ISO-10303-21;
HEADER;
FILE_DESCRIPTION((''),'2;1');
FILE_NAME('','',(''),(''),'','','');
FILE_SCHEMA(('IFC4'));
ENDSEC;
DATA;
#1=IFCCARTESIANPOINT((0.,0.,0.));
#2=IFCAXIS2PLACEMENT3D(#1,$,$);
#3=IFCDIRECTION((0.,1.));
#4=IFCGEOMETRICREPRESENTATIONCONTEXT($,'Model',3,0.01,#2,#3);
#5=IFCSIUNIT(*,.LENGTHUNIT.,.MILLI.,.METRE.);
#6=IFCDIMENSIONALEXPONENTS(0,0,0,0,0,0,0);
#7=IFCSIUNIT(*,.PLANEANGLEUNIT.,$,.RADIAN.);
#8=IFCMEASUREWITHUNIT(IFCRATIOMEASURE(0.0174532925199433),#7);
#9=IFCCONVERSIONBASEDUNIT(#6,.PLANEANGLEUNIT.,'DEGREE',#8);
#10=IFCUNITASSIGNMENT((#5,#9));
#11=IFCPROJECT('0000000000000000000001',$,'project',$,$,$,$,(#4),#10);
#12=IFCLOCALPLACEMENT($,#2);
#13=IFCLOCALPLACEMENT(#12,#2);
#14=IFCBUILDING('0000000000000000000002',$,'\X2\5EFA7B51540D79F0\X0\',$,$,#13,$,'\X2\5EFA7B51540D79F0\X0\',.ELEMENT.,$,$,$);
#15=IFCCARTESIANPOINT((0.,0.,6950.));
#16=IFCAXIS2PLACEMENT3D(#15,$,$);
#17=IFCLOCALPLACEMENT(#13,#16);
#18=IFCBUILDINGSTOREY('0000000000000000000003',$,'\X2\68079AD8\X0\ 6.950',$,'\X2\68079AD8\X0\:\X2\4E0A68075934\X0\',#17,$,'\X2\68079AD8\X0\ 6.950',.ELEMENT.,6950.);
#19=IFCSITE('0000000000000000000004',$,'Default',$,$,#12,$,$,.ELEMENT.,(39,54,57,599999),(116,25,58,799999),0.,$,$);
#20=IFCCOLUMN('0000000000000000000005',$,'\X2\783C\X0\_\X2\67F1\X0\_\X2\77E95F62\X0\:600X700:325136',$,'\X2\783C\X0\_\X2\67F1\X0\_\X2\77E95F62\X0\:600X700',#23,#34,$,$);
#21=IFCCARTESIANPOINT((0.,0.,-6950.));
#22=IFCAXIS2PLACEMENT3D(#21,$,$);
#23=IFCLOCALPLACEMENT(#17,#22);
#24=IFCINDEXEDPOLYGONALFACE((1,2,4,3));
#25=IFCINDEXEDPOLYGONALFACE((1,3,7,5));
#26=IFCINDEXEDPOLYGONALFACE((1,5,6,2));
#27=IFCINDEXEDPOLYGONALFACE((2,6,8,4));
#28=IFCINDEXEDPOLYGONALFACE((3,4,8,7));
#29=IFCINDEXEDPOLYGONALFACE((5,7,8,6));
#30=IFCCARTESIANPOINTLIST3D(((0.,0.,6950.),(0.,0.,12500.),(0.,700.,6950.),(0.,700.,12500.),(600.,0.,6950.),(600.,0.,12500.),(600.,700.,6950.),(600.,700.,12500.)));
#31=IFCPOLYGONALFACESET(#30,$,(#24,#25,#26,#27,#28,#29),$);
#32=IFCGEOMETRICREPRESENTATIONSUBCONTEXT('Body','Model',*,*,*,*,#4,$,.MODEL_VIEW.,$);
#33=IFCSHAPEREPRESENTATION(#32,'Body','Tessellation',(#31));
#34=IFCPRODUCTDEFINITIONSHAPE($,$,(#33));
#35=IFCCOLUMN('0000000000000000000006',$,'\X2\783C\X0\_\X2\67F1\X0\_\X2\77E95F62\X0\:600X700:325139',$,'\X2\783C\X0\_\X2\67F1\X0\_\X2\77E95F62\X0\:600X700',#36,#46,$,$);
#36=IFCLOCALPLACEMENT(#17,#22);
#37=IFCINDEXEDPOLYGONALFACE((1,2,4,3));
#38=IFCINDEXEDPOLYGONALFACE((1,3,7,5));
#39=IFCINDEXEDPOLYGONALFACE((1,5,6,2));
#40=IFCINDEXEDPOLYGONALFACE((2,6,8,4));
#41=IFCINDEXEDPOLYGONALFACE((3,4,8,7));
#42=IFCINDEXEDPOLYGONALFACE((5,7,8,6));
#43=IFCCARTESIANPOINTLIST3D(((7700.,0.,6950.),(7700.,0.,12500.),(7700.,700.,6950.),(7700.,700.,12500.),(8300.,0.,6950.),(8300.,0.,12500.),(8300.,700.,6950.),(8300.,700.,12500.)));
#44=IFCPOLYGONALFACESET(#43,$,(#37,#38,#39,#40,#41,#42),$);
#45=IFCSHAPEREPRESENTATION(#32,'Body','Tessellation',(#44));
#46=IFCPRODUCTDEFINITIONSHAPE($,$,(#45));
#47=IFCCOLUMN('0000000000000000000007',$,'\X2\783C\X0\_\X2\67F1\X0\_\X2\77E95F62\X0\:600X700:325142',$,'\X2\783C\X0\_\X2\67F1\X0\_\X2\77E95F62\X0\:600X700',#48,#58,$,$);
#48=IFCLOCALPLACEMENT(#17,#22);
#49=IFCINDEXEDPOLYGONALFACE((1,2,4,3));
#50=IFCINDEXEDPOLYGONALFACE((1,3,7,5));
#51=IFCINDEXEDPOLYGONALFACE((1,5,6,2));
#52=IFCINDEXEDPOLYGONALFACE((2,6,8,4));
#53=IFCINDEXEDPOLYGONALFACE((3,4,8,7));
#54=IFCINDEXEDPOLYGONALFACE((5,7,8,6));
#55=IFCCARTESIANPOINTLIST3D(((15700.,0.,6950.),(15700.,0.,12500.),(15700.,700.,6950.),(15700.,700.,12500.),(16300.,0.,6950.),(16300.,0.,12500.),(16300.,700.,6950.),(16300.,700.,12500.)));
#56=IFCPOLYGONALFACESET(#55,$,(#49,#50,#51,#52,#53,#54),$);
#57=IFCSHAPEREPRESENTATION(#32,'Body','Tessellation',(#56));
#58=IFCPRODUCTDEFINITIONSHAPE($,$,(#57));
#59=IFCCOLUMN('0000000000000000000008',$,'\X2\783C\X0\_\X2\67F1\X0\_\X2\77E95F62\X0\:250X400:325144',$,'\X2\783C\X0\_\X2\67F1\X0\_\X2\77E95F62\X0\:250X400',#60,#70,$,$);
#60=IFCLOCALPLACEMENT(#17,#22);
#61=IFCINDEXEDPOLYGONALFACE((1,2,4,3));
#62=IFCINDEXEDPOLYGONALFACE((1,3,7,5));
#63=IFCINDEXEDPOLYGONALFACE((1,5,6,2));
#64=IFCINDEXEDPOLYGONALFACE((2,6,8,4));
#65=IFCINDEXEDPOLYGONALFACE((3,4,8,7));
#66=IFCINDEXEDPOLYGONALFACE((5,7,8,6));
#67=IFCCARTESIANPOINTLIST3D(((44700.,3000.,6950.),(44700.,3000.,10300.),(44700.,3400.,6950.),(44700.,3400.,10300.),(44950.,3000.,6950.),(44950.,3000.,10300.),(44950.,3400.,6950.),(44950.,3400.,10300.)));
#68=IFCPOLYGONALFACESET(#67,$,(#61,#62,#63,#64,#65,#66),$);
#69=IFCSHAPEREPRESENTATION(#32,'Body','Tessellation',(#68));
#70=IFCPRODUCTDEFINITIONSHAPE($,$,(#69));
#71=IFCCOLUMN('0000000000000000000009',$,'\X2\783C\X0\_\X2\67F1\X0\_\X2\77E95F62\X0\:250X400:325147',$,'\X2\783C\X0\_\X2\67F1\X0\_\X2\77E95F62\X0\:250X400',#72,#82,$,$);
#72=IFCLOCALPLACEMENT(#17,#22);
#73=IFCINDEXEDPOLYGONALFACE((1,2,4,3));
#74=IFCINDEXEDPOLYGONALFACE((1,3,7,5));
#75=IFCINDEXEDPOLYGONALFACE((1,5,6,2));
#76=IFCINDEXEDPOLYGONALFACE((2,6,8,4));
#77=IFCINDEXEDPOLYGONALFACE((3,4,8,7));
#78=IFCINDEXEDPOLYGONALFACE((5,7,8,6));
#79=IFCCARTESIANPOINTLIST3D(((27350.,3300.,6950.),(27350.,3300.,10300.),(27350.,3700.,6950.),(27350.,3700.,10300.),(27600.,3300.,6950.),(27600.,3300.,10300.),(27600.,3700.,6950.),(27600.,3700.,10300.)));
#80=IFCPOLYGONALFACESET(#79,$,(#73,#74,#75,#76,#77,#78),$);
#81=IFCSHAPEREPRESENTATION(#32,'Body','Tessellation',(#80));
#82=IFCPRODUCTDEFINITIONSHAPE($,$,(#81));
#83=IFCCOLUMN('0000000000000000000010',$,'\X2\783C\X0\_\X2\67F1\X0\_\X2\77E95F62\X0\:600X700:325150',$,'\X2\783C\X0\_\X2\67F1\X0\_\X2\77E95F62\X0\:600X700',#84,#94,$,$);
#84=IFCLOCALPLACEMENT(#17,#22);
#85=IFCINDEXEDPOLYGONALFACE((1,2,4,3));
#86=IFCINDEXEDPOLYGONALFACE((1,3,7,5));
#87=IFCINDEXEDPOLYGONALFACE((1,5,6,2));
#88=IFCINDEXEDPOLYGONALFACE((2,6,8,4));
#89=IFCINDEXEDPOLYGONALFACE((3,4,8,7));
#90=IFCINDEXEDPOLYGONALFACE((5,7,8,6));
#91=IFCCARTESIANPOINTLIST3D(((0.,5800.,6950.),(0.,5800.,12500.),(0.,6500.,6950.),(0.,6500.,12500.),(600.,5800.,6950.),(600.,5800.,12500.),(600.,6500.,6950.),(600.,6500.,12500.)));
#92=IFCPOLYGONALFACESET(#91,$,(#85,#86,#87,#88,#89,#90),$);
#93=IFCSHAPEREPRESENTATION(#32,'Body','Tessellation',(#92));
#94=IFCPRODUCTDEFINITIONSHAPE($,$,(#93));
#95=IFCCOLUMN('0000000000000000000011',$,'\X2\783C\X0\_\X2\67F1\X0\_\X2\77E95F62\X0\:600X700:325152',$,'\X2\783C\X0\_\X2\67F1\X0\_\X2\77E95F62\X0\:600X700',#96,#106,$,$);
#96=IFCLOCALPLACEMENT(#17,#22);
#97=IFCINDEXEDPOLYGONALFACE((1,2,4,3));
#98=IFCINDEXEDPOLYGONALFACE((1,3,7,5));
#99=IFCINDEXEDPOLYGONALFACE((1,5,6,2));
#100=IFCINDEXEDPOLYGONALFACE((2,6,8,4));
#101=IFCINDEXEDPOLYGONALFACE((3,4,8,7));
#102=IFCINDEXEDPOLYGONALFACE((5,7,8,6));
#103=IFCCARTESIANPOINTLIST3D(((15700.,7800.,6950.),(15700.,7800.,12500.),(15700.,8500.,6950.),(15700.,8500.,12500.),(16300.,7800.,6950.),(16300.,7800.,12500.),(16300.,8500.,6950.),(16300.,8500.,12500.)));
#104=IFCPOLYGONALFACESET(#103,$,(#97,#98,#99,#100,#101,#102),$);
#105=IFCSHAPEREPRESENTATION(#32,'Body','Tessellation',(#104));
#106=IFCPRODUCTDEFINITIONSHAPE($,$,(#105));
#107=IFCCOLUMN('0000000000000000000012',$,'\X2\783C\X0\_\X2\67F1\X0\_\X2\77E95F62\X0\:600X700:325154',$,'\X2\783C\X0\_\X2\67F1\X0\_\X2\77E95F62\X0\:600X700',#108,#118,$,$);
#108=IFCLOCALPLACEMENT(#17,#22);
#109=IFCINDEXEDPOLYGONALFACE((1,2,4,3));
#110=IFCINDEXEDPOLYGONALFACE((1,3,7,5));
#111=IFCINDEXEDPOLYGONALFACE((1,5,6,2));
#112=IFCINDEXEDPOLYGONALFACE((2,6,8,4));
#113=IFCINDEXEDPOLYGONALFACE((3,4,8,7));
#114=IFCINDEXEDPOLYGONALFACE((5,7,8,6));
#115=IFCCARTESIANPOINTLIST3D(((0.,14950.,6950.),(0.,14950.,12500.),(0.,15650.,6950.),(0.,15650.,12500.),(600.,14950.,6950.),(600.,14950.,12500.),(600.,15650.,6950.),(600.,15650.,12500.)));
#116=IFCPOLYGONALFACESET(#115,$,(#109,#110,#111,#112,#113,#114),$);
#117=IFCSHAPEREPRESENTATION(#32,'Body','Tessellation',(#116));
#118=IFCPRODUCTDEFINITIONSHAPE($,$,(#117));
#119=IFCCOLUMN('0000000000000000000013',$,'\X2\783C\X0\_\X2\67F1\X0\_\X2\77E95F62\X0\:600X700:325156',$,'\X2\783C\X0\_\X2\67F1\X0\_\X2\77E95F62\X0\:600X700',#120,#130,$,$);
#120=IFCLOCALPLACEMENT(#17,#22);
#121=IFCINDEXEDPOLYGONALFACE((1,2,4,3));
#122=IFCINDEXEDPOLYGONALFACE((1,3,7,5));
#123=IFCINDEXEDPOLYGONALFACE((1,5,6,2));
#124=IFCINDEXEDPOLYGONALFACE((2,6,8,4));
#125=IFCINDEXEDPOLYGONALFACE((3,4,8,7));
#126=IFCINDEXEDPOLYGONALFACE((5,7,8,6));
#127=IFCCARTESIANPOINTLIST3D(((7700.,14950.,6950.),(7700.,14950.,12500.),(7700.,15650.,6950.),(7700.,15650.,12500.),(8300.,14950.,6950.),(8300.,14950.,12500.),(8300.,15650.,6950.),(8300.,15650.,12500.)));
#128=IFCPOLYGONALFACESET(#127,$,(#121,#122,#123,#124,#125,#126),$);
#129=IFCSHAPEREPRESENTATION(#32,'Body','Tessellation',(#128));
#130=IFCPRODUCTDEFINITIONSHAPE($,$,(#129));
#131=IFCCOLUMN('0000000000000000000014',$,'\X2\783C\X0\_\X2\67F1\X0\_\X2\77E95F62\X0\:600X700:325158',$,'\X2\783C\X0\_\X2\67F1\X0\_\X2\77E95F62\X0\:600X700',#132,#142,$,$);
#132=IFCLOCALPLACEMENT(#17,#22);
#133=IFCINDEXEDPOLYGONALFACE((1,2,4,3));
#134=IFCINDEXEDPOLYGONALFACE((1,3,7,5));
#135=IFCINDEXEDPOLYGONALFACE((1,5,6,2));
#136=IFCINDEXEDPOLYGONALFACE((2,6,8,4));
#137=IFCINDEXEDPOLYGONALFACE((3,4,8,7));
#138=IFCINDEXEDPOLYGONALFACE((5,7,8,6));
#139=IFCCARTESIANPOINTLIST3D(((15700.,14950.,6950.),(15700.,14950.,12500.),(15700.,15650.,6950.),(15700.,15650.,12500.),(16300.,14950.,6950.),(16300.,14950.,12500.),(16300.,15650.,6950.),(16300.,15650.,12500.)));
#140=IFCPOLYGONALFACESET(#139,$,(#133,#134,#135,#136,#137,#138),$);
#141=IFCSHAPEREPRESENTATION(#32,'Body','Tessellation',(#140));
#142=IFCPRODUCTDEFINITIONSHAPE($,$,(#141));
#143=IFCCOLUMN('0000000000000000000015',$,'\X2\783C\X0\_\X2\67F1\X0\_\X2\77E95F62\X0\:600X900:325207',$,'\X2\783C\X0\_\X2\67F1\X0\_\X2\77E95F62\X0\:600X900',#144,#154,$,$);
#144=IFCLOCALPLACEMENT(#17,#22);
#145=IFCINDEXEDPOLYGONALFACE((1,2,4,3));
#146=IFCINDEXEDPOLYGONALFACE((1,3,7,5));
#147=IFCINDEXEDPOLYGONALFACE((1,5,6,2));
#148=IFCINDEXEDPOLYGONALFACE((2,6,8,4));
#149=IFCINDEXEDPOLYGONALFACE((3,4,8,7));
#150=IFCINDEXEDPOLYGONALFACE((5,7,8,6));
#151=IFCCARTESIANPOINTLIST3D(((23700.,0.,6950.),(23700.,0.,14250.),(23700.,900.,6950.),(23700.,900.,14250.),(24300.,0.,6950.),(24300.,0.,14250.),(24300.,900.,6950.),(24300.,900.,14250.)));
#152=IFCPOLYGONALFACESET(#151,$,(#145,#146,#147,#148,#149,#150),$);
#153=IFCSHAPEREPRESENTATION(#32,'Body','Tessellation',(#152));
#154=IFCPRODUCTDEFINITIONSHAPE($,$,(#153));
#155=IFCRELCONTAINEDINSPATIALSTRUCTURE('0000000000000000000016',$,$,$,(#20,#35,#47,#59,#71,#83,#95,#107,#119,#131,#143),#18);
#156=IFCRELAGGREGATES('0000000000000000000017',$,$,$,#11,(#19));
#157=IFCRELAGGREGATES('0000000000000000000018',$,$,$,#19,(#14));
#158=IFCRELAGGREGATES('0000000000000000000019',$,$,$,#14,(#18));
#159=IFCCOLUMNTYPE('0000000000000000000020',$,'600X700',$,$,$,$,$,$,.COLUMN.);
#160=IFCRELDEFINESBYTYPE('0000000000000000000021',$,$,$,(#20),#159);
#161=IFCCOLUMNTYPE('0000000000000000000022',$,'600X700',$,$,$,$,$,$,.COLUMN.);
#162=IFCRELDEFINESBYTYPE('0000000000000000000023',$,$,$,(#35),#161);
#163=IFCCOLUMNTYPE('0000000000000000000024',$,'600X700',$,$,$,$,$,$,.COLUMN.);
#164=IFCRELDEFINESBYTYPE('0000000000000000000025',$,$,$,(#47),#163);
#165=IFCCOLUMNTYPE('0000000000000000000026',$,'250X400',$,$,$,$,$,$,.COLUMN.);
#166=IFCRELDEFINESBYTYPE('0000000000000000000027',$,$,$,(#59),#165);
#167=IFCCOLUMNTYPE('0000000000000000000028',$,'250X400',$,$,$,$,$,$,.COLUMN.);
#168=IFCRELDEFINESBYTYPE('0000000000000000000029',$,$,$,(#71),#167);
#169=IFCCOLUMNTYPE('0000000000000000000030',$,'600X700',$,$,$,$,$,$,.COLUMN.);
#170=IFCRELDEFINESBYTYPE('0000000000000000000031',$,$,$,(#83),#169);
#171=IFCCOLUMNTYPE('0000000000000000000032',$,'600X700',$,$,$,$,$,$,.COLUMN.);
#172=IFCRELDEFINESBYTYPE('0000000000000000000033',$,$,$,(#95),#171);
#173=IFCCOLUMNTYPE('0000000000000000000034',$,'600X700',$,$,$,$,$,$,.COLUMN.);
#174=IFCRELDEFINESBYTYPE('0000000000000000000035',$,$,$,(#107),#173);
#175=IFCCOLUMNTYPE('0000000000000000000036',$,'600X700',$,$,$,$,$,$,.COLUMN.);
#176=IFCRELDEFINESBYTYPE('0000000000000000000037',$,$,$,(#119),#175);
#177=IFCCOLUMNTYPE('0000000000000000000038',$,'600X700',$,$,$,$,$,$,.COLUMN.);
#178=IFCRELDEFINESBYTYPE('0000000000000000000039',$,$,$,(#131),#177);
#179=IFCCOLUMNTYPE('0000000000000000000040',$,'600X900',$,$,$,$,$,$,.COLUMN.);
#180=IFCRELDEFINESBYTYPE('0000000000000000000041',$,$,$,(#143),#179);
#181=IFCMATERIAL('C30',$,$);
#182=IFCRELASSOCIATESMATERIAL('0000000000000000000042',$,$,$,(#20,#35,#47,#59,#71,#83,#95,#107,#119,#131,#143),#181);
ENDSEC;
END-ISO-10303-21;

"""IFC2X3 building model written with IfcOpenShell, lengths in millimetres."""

from ifc_helpers import new_model, entity, si_unit, converted_unit, direction, frame, frame_2d, origin, origin_2d_with_axis, place, context, subcontext, project, spatial, rectangle, extrude, source, transform, mapped, material, type_object, type_shapes, element, save


model = new_model("IFC2X3")

# Units and contexts
model_context = context("Model", 3, precision=0.01, world=origin(), true_north=direction((0.0, 1.0)))
body_context = subcontext(model_context, "Body", "Model", "MODEL_VIEW")
ifc_project = project(units=[si_unit("LENGTHUNIT", "METRE", prefix="MILLI"), converted_unit("PLANEANGLEUNIT", "DEGREE", entity("IfcRatioMeasure", 0.0174532925199433), si_unit("PLANEANGLEUNIT", "RADIAN"), dimensions=[0, 0, 0, 0, 0, 0, 0])], contexts=[model_context])

# Site, building, storey
site_placement = place(None, origin())
site = spatial("IfcSite", under=ifc_project, at=site_placement, Name="Default", CompositionType="ELEMENT", RefLatitude=(39, 54, 57, 599999), RefLongitude=(116, 25, 58, 799999), RefElevation=0.0)
building_placement = place(site_placement, origin())
building = spatial("IfcBuilding", under=site, at=building_placement, Name="建筑名称", LongName="建筑名称", CompositionType="ELEMENT")
storey_placement = place(building_placement, frame((0.0, 0.0, 6950.0)))
storey = spatial("IfcBuildingStorey", under=building, at=storey_placement, Name="标高 6.950", ObjectType="标高:上标头", LongName="标高 6.950", CompositionType="ELEMENT", Elevation=6950.0)

# Columns
ifc_material = material(Name="C30")
column_type_1 = type_object("IfcColumnType", Name="600X700", PredefinedType="COLUMN")
shared_shape_1 = source(origin(), body_context, "Body", "SweptSolid", [
    extrude(rectangle(XDim=700.0, YDim=600.0, at=origin_2d_with_axis()), frame((300.0, 350.0, 6950.0), z_axis=(0.0, 0.0, 1.0), x_axis=(0.0, -1.0, 0.0)), (0.0, 0.0, 1.0), 5550.0),
])
type_shapes(column_type_1, [shared_shape_1])
column_1_placement = place(storey_placement, frame((0.0, 0.0, -6950.0)))
element("IfcColumn", 1, at=column_1_placement, inside=storey, type_object=column_type_1, material=ifc_material, Name="砼_柱_矩形:600X700:325136", ObjectType="砼_柱_矩形:600X700", context=body_context, shape_type="MappedRepresentation", body=[
    mapped(shared_shape_1, transform((0.0, 0.0, 0.0), scale=1.0)),
])
column_type_2 = type_object("IfcColumnType", Name="600X700", PredefinedType="COLUMN")
shared_shape_2 = source(origin(), body_context, "Body", "SweptSolid", [
    extrude(rectangle(XDim=700.0, YDim=600.0, at=origin_2d_with_axis()), frame((8000.0, 350.0, 6950.0), z_axis=(0.0, 0.0, 1.0), x_axis=(0.0, -1.0, 0.0)), (0.0, 0.0, 1.0), 5550.0),
])
type_shapes(column_type_2, [shared_shape_2])
column_2_placement = place(storey_placement, frame((0.0, 0.0, -6950.0)))
element("IfcColumn", 2, at=column_2_placement, inside=storey, type_object=column_type_2, material=ifc_material, Name="砼_柱_矩形:600X700:325139", ObjectType="砼_柱_矩形:600X700", context=body_context, shape_type="MappedRepresentation", body=[
    mapped(shared_shape_2, transform((0.0, 0.0, 0.0), scale=1.0)),
])
column_type_3 = type_object("IfcColumnType", Name="600X700", PredefinedType="COLUMN")
shared_shape_3 = source(origin(), body_context, "Body", "SweptSolid", [
    extrude(rectangle(XDim=700.0, YDim=600.0, at=frame_2d((0.0, 0.0), x_axis=(1.0, 0.0))), frame((16000.0, 350.0, 6950.0), z_axis=(0.0, 0.0, 1.0), x_axis=(0.0, -1.0, 0.0)), (0.0, 0.0, 1.0), 5550.0),
])
type_shapes(column_type_3, [shared_shape_3])
column_3_placement = place(storey_placement, frame((0.0, 0.0, -6950.0)))
element("IfcColumn", 3, at=column_3_placement, inside=storey, type_object=column_type_3, material=ifc_material, Name="砼_柱_矩形:600X700:325142", ObjectType="砼_柱_矩形:600X700", context=body_context, shape_type="MappedRepresentation", body=[
    mapped(shared_shape_3, transform((0.0, 0.0, 0.0), scale=1.0)),
])
column_type_4 = type_object("IfcColumnType", Name="250X400", PredefinedType="COLUMN")
shared_shape_4 = source(origin(), body_context, "Body", "SweptSolid", [
    extrude(rectangle(XDim=400.0, YDim=250.0, at=origin_2d_with_axis()), frame((44825.0, 3200.0, 6950.0), z_axis=(0.0, 0.0, 1.0), x_axis=(0.0, -1.0, 0.0)), (0.0, 0.0, 1.0), 3350.0),
])
type_shapes(column_type_4, [shared_shape_4])
column_4_placement = place(storey_placement, frame((0.0, 0.0, -6950.0)))
element("IfcColumn", 4, at=column_4_placement, inside=storey, type_object=column_type_4, material=ifc_material, Name="砼_柱_矩形:250X400:325144", ObjectType="砼_柱_矩形:250X400", context=body_context, shape_type="MappedRepresentation", body=[
    mapped(shared_shape_4, transform((0.0, 0.0, 0.0), scale=1.0)),
])
column_type_5 = type_object("IfcColumnType", Name="250X400", PredefinedType="COLUMN")
shared_shape_5 = source(origin(), body_context, "Body", "SweptSolid", [
    extrude(rectangle(XDim=400.0, YDim=250.0, at=origin_2d_with_axis()), frame((27475.0, 3500.0, 6950.0), z_axis=(0.0, 0.0, 1.0), x_axis=(0.0, -1.0, 0.0)), (0.0, 0.0, 1.0), 3350.0),
])
type_shapes(column_type_5, [shared_shape_5])
column_5_placement = place(storey_placement, frame((0.0, 0.0, -6950.0)))
element("IfcColumn", 5, at=column_5_placement, inside=storey, type_object=column_type_5, material=ifc_material, Name="砼_柱_矩形:250X400:325147", ObjectType="砼_柱_矩形:250X400", context=body_context, shape_type="MappedRepresentation", body=[
    mapped(shared_shape_5, transform((0.0, 0.0, 0.0), scale=1.0)),
])
column_type_6 = type_object("IfcColumnType", Name="600X700", PredefinedType="COLUMN")
shared_shape_6 = source(origin(), body_context, "Body", "SweptSolid", [
    extrude(rectangle(XDim=700.0, YDim=600.0, at=origin_2d_with_axis()), frame((300.0, 6150.0, 6950.0), z_axis=(0.0, 0.0, 1.0), x_axis=(0.0, -1.0, 0.0)), (0.0, 0.0, 1.0), 5550.0),
])
type_shapes(column_type_6, [shared_shape_6])
column_6_placement = place(storey_placement, frame((0.0, 0.0, -6950.0)))
element("IfcColumn", 6, at=column_6_placement, inside=storey, type_object=column_type_6, material=ifc_material, Name="砼_柱_矩形:600X700:325150", ObjectType="砼_柱_矩形:600X700", context=body_context, shape_type="MappedRepresentation", body=[
    mapped(shared_shape_6, transform((0.0, 0.0, 0.0), scale=1.0)),
])
column_type_7 = type_object("IfcColumnType", Name="600X700", PredefinedType="COLUMN")
shared_shape_7 = source(origin(), body_context, "Body", "SweptSolid", [
    extrude(rectangle(XDim=700.0, YDim=600.0, at=frame_2d((0.0, 0.0), x_axis=(1.0, 0.0))), frame((16000.0, 8150.0, 6950.0), z_axis=(0.0, 0.0, 1.0), x_axis=(0.0, -1.0, 0.0)), (0.0, 0.0, 1.0), 5550.0),
])
type_shapes(column_type_7, [shared_shape_7])
column_7_placement = place(storey_placement, frame((0.0, 0.0, -6950.0)))
element("IfcColumn", 7, at=column_7_placement, inside=storey, type_object=column_type_7, material=ifc_material, Name="砼_柱_矩形:600X700:325152", ObjectType="砼_柱_矩形:600X700", context=body_context, shape_type="MappedRepresentation", body=[
    mapped(shared_shape_7, transform((0.0, 0.0, 0.0), scale=1.0)),
])
column_type_8 = type_object("IfcColumnType", Name="600X700", PredefinedType="COLUMN")
shared_shape_8 = source(origin(), body_context, "Body", "SweptSolid", [
    extrude(rectangle(XDim=700.0, YDim=600.0, at=origin_2d_with_axis()), frame((300.0, 15300.0, 6950.0), z_axis=(0.0, 0.0, 1.0), x_axis=(0.0, -1.0, 0.0)), (0.0, 0.0, 1.0), 5550.0),
])
type_shapes(column_type_8, [shared_shape_8])
column_8_placement = place(storey_placement, frame((0.0, 0.0, -6950.0)))
element("IfcColumn", 8, at=column_8_placement, inside=storey, type_object=column_type_8, material=ifc_material, Name="砼_柱_矩形:600X700:325154", ObjectType="砼_柱_矩形:600X700", context=body_context, shape_type="MappedRepresentation", body=[
    mapped(shared_shape_8, transform((0.0, 0.0, 0.0), scale=1.0)),
])
column_type_9 = type_object("IfcColumnType", Name="600X700", PredefinedType="COLUMN")
shared_shape_9 = source(origin(), body_context, "Body", "SweptSolid", [
    extrude(rectangle(XDim=700.0, YDim=600.0, at=origin_2d_with_axis()), frame((8000.0, 15300.0, 6950.0), z_axis=(0.0, 0.0, 1.0), x_axis=(0.0, -1.0, 0.0)), (0.0, 0.0, 1.0), 5550.0),
])
type_shapes(column_type_9, [shared_shape_9])
column_9_placement = place(storey_placement, frame((0.0, 0.0, -6950.0)))
element("IfcColumn", 9, at=column_9_placement, inside=storey, type_object=column_type_9, material=ifc_material, Name="砼_柱_矩形:600X700:325156", ObjectType="砼_柱_矩形:600X700", context=body_context, shape_type="MappedRepresentation", body=[
    mapped(shared_shape_9, transform((0.0, 0.0, 0.0), scale=1.0)),
])
column_type_10 = type_object("IfcColumnType", Name="600X700", PredefinedType="COLUMN")
shared_shape_10 = source(origin(), body_context, "Body", "SweptSolid", [
    extrude(rectangle(XDim=700.0, YDim=600.0, at=frame_2d((0.0, 0.0), x_axis=(1.0, 0.0))), frame((16000.0, 15300.0, 6950.0), z_axis=(0.0, 0.0, 1.0), x_axis=(0.0, -1.0, 0.0)), (0.0, 0.0, 1.0), 5550.0),
])
type_shapes(column_type_10, [shared_shape_10])
column_10_placement = place(storey_placement, frame((0.0, 0.0, -6950.0)))
element("IfcColumn", 10, at=column_10_placement, inside=storey, type_object=column_type_10, material=ifc_material, Name="砼_柱_矩形:600X700:325158", ObjectType="砼_柱_矩形:600X700", context=body_context, shape_type="MappedRepresentation", body=[
    mapped(shared_shape_10, transform((0.0, 0.0, 0.0), scale=1.0)),
])
column_type_11 = type_object("IfcColumnType", Name="600X900", PredefinedType="COLUMN")
shared_shape_11 = source(origin(), body_context, "Body", "SweptSolid", [
    extrude(rectangle(XDim=900.0, YDim=600.0, at=origin_2d_with_axis()), frame((24000.0, 450.0, 6950.0), z_axis=(0.0, 0.0, 1.0), x_axis=(0.0, -1.0, 0.0)), (0.0, 0.0, 1.0), 7300.0),
])
type_shapes(column_type_11, [shared_shape_11])
column_11_placement = place(storey_placement, frame((0.0, 0.0, -6950.0)))
element("IfcColumn", 11, at=column_11_placement, inside=storey, type_object=column_type_11, material=ifc_material, Name="砼_柱_矩形:600X900:325207", ObjectType="砼_柱_矩形:600X900", context=body_context, shape_type="MappedRepresentation", body=[
    mapped(shared_shape_11, transform((0.0, 0.0, 0.0), scale=1.0)),
])

save(model, "model.ifc")
